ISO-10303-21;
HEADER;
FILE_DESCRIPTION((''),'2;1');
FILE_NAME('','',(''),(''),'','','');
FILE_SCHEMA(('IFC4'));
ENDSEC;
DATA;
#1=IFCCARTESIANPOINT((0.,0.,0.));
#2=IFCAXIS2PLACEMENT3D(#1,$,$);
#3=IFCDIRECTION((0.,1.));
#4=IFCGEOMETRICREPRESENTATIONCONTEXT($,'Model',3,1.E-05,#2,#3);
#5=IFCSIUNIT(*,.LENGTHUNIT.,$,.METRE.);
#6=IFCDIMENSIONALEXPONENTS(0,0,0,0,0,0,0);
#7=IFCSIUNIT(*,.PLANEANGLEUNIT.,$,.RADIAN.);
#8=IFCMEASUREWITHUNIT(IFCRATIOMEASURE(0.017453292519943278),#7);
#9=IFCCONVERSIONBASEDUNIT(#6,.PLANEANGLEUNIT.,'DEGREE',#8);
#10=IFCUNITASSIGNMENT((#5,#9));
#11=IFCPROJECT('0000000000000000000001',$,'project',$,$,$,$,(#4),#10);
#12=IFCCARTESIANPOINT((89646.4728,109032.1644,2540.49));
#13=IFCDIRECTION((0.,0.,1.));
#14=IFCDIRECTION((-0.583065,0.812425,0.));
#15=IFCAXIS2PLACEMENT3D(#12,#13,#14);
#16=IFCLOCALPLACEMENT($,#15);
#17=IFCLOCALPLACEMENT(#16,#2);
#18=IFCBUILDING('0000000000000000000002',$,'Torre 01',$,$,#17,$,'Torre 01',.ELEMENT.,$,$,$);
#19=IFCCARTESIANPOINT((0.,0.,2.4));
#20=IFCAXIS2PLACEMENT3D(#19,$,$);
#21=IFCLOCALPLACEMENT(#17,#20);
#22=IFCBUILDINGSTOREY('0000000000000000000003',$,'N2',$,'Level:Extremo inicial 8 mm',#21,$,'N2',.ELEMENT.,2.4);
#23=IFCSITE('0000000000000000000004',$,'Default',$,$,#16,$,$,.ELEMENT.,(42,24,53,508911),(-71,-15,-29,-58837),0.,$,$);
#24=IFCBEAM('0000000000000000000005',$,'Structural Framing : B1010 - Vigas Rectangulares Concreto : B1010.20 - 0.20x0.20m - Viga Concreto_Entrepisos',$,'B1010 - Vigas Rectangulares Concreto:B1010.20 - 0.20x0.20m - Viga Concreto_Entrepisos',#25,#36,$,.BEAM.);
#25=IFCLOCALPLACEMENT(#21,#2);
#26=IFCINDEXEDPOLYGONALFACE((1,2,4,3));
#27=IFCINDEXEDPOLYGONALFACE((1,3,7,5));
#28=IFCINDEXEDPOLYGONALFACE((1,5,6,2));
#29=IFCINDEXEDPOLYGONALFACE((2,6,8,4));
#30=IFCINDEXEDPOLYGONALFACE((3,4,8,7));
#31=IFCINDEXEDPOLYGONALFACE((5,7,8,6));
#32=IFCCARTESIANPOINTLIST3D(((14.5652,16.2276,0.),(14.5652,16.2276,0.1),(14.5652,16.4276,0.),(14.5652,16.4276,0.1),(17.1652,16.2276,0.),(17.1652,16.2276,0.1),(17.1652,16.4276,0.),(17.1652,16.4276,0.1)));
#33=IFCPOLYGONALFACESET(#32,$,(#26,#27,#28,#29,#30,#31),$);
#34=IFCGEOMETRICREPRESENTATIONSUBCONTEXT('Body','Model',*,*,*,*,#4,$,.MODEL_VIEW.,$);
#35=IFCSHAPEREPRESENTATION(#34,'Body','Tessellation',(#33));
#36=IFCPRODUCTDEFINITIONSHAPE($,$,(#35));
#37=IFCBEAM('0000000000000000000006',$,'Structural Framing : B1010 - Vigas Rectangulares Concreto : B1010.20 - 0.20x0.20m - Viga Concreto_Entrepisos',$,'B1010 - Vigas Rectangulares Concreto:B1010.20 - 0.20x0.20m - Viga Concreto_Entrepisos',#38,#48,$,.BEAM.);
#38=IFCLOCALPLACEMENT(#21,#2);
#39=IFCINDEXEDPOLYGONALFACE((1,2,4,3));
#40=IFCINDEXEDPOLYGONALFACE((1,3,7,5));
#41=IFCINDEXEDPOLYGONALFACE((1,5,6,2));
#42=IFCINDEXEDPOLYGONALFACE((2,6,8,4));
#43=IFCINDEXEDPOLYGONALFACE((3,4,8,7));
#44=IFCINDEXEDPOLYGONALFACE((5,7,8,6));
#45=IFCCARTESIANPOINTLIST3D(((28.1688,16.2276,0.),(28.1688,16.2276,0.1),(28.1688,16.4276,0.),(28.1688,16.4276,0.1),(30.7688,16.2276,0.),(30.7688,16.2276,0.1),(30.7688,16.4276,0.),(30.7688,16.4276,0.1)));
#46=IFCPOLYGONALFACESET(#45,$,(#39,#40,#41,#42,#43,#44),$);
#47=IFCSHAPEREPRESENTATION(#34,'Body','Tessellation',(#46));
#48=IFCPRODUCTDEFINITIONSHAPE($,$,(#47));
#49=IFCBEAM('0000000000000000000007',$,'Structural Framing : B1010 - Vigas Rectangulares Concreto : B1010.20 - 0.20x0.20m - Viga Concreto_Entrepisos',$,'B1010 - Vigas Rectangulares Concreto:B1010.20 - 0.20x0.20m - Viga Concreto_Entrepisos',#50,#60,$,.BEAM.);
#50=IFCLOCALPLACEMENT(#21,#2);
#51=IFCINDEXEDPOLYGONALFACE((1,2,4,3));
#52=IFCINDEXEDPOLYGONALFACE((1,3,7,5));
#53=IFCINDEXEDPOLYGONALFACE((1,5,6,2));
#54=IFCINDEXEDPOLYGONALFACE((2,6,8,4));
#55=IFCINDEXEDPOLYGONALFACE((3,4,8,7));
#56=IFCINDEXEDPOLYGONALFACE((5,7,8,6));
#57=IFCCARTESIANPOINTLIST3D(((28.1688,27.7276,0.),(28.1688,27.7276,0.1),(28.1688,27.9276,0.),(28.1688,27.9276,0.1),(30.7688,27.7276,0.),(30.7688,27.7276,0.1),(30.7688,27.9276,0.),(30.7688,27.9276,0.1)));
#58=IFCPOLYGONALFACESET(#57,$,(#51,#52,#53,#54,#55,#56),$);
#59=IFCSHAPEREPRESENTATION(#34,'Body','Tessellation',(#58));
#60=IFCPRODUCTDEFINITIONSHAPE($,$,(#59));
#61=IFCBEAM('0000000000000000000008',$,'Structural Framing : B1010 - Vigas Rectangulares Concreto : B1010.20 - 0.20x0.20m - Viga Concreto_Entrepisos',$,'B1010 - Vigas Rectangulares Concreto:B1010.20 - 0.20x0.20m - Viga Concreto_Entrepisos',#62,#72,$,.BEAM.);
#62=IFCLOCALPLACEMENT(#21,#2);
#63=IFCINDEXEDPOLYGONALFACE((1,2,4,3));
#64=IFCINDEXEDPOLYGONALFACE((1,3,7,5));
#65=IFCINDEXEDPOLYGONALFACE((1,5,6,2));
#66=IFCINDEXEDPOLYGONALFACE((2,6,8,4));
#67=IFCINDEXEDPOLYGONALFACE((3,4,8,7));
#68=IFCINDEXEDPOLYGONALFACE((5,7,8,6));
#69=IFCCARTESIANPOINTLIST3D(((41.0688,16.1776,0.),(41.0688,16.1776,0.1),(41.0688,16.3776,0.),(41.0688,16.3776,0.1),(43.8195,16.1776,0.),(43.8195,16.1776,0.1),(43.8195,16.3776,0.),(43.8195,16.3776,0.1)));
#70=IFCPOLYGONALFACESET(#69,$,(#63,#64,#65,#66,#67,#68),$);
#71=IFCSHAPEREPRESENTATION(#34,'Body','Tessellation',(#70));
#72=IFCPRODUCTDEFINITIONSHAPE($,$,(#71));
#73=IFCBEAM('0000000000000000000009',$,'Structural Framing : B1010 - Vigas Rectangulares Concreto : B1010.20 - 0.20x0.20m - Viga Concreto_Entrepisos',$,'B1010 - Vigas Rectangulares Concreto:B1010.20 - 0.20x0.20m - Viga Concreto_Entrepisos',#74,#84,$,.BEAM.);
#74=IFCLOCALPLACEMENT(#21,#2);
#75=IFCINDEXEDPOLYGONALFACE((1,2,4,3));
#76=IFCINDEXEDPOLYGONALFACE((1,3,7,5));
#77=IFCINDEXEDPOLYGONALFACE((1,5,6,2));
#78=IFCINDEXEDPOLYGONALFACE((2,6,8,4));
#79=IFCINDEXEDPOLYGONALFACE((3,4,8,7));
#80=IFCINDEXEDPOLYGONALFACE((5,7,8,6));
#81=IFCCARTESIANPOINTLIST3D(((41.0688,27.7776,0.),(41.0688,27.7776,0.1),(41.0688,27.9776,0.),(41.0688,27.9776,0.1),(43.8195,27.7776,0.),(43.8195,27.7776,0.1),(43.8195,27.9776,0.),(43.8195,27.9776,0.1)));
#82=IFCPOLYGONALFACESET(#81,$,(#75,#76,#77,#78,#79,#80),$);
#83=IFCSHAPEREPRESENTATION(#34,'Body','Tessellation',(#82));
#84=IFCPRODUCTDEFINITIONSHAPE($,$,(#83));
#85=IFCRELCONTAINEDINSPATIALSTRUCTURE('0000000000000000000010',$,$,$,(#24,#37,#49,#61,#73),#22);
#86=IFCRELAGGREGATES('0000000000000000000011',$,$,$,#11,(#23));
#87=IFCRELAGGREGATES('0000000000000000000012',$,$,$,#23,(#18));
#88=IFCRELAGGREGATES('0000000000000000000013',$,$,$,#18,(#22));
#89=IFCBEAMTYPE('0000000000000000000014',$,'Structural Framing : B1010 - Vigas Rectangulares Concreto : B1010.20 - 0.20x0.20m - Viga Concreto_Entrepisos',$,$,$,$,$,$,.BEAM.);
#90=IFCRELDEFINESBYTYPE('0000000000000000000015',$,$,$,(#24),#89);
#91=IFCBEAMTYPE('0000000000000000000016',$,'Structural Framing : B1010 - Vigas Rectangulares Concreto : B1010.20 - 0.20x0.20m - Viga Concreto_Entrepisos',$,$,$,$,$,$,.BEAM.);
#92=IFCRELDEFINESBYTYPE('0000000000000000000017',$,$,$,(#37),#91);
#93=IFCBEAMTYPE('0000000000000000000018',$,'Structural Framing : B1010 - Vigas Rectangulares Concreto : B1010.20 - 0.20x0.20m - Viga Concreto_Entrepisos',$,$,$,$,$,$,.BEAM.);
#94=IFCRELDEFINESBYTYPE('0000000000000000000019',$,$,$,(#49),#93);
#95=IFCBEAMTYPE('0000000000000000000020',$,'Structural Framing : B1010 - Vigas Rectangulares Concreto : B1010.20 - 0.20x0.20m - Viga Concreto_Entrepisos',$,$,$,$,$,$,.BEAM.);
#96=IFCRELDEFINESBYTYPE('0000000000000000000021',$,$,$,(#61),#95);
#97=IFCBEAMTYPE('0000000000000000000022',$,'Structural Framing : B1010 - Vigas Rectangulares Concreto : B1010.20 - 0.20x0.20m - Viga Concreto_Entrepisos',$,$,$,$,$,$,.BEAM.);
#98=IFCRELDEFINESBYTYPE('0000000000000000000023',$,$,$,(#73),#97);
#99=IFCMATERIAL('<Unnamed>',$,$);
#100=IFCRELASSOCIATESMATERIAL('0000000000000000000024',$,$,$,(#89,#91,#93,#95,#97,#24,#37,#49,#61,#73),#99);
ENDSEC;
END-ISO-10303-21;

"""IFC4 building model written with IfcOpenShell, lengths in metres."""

from ifc_helpers import new_model, entity, si_unit, converted_unit, direction, frame, frame_2d, origin, origin_2d_with_axis, place, context, subcontext, project, spatial, polyline, segment, composite_curve, rectangle, outline, extrude, source, transform, mapped, material, material_profile, profile_set, profile_usage, type_object, type_shapes, element, save


model = new_model("IFC4")

# Units and contexts
model_context = context("Model", 3, precision=1e-05, world=origin(), true_north=direction((0.0, 1.0)))
body_context = subcontext(model_context, "Body", "Model", "MODEL_VIEW")
ifc_project = project(units=[si_unit("LENGTHUNIT", "METRE"), converted_unit("PLANEANGLEUNIT", "DEGREE", entity("IfcRatioMeasure", 0.017453292519943278), si_unit("PLANEANGLEUNIT", "RADIAN"), dimensions=[0, 0, 0, 0, 0, 0, 0])], contexts=[model_context])

# Site, building, storey
site_placement = place(None, frame((89646.4728, 109032.1644, 2540.49), z_axis=(0.0, 0.0, 1.0), x_axis=(-0.583065, 0.812425, 0.0)))
site = spatial("IfcSite", under=ifc_project, at=site_placement, Name="Default", CompositionType="ELEMENT", RefLatitude=(42, 24, 53, 508911), RefLongitude=(-71, -15, -29, -58837), RefElevation=0.0)
building_placement = place(site_placement, origin())
building = spatial("IfcBuilding", under=site, at=building_placement, Name="Torre 01", LongName="Torre 01", CompositionType="ELEMENT")
storey_placement = place(building_placement, frame((0.0, 0.0, 2.4)))
storey = spatial("IfcBuildingStorey", under=building, at=storey_placement, Name="N2", ObjectType="Level:Extremo inicial 8 mm", LongName="N2", CompositionType="ELEMENT", Elevation=2.4)

# Beams
ifc_material = material(Name="<Unnamed>")
ifc_material_profile_1 = material_profile(ifc_material, outline(composite_curve([segment(polyline([(-0.1, 0.0, 0.0), (-0.1, 0.1, 0.0)]), True, "CONTINUOUS"), segment(polyline([(-0.1, 0.1, 0.0), (0.1, 0.1, 0.0)]), True, "CONTINUOUS"), segment(polyline([(0.1, 0.1, 0.0), (0.1, 0.0, 0.0)]), True, "CONTINUOUS"), segment(polyline([(0.1, 0.0, 0.0), (-0.1, 0.0, 0.0)]), True, "CONTINUOUS")], self_intersect=False), kind="CURVE"), Name="B1010.20 - 0.20x0.20m - Viga Concreto_Entrepisos")
ifc_material_profile_2 = material_profile(ifc_material, outline(composite_curve([segment(polyline([(-1.3, -0.1, 0.1), (-1.3, 0.1, 0.1)]), True, "CONTINUOUS"), segment(polyline([(-1.3, 0.1, 0.1), (-1.3, 0.1, -0.1)]), True, "CONTINUOUS"), segment(polyline([(-1.3, 0.1, -0.1), (-1.3, -0.1, -0.1)]), True, "CONTINUOUS"), segment(polyline([(-1.3, -0.1, -0.1), (-1.3, -0.1, 0.1)]), True, "CONTINUOUS")], self_intersect=False), kind="CURVE"), Name="B1010.20 - 0.20x0.20m - Viga Concreto_Entrepisos")
ifc_profile_set_1 = profile_set([ifc_material_profile_1, ifc_material_profile_2], Name="B1010.20 - 0.20x0.20m - Viga Concreto_Entrepisos")
ifc_profile_usage_1 = profile_usage(ifc_profile_set_1, cardinal=8)
beam_type_1 = type_object("IfcBeamType", Name="Structural Framing : B1010 - Vigas Rectangulares Concreto : B1010.20 - 0.20x0.20m - Viga Concreto_Entrepisos", PredefinedType="BEAM", material=ifc_profile_set_1)
shared_shape_1 = source(origin(), body_context, "Body", "SweptSolid", [
    extrude(rectangle(XDim=0.1, YDim=0.2, at=frame_2d((0.0, 0.0), x_axis=(1.0, 0.0))), frame((17.1652, 16.3276, 2.45), z_axis=(-1.0, 0.0, 0.0), x_axis=(0.0, 0.0, -1.0)), (0.0, 0.0, 1.0), 2.6),
])
type_shapes(beam_type_1, [shared_shape_1])
beam_1_placement = place(storey_placement, frame((0.0, 0.0, -2.4)))
element("IfcBeam", 1, at=beam_1_placement, inside=storey, type_object=beam_type_1, material=ifc_profile_usage_1, Name="Structural Framing : B1010 - Vigas Rectangulares Concreto : B1010.20 - 0.20x0.20m - Viga Concreto_Entrepisos", ObjectType="B1010 - Vigas Rectangulares Concreto:B1010.20 - 0.20x0.20m - Viga Concreto_Entrepisos", PredefinedType="BEAM", context=body_context, shape_type="MappedRepresentation", body=[
    mapped(shared_shape_1, transform((0.0, 0.0, 0.0), scale=1.0)),
])
ifc_profile_usage_2 = profile_usage(ifc_profile_set_1, cardinal=8)
beam_type_2 = type_object("IfcBeamType", Name="Structural Framing : B1010 - Vigas Rectangulares Concreto : B1010.20 - 0.20x0.20m - Viga Concreto_Entrepisos", PredefinedType="BEAM", material=ifc_profile_set_1)
shared_shape_2 = source(origin(), body_context, "Body", "SweptSolid", [
    extrude(rectangle(XDim=0.1, YDim=0.2, at=frame_2d((0.0, 0.0), x_axis=(1.0, 0.0))), frame((28.1688, 16.3276, 2.45), z_axis=(1.0, 0.0, 0.0), x_axis=(0.0, 0.0, -1.0)), (0.0, 0.0, 1.0), 2.6),
])
type_shapes(beam_type_2, [shared_shape_2])
beam_2_placement = place(storey_placement, frame((0.0, 0.0, -2.4)))
element("IfcBeam", 2, at=beam_2_placement, inside=storey, type_object=beam_type_2, material=ifc_profile_usage_2, Name="Structural Framing : B1010 - Vigas Rectangulares Concreto : B1010.20 - 0.20x0.20m - Viga Concreto_Entrepisos", ObjectType="B1010 - Vigas Rectangulares Concreto:B1010.20 - 0.20x0.20m - Viga Concreto_Entrepisos", PredefinedType="BEAM", context=body_context, shape_type="MappedRepresentation", body=[
    mapped(shared_shape_2, transform((0.0, 0.0, 0.0), scale=1.0)),
])
ifc_profile_usage_3 = profile_usage(ifc_profile_set_1, cardinal=8)
beam_type_3 = type_object("IfcBeamType", Name="Structural Framing : B1010 - Vigas Rectangulares Concreto : B1010.20 - 0.20x0.20m - Viga Concreto_Entrepisos", PredefinedType="BEAM", material=ifc_profile_set_1)
shared_shape_3 = source(origin(), body_context, "Body", "SweptSolid", [
    extrude(rectangle(XDim=0.1, YDim=0.2, at=origin_2d_with_axis()), frame((28.1688, 27.8276, 2.45), z_axis=(1.0, 0.0, 0.0), x_axis=(0.0, 0.0, -1.0)), (0.0, 0.0, 1.0), 2.6),
])
type_shapes(beam_type_3, [shared_shape_3])
beam_3_placement = place(storey_placement, frame((0.0, 0.0, -2.4)))
element("IfcBeam", 3, at=beam_3_placement, inside=storey, type_object=beam_type_3, material=ifc_profile_usage_3, Name="Structural Framing : B1010 - Vigas Rectangulares Concreto : B1010.20 - 0.20x0.20m - Viga Concreto_Entrepisos", ObjectType="B1010 - Vigas Rectangulares Concreto:B1010.20 - 0.20x0.20m - Viga Concreto_Entrepisos", PredefinedType="BEAM", context=body_context, shape_type="MappedRepresentation", body=[
    mapped(shared_shape_3, transform((0.0, 0.0, 0.0), scale=1.0)),
])
ifc_profile_usage_4 = profile_usage(ifc_profile_set_1, cardinal=8)
beam_type_4 = type_object("IfcBeamType", Name="Structural Framing : B1010 - Vigas Rectangulares Concreto : B1010.20 - 0.20x0.20m - Viga Concreto_Entrepisos", PredefinedType="BEAM", material=ifc_profile_set_1)
shared_shape_4 = source(origin(), body_context, "Body", "SweptSolid", [
    extrude(rectangle(XDim=0.1, YDim=0.2, at=frame_2d((0.0, 0.0), x_axis=(1.0, 0.0))), frame((43.8195, 16.2776, 2.45), z_axis=(-1.0, 0.0, 0.0), x_axis=(0.0, 0.0, -1.0)), (0.0, 0.0, 1.0), 2.7507),
])
type_shapes(beam_type_4, [shared_shape_4])
beam_4_placement = place(storey_placement, frame((0.0, 0.0, -2.4)))
element("IfcBeam", 4, at=beam_4_placement, inside=storey, type_object=beam_type_4, material=ifc_profile_usage_4, Name="Structural Framing : B1010 - Vigas Rectangulares Concreto : B1010.20 - 0.20x0.20m - Viga Concreto_Entrepisos", ObjectType="B1010 - Vigas Rectangulares Concreto:B1010.20 - 0.20x0.20m - Viga Concreto_Entrepisos", PredefinedType="BEAM", context=body_context, shape_type="MappedRepresentation", body=[
    mapped(shared_shape_4, transform((0.0, 0.0, 0.0), scale=1.0)),
])
ifc_profile_usage_5 = profile_usage(ifc_profile_set_1, cardinal=8)
beam_type_5 = type_object("IfcBeamType", Name="Structural Framing : B1010 - Vigas Rectangulares Concreto : B1010.20 - 0.20x0.20m - Viga Concreto_Entrepisos", PredefinedType="BEAM", material=ifc_profile_set_1)
shared_shape_5 = source(origin(), body_context, "Body", "SweptSolid", [
    extrude(rectangle(XDim=0.1, YDim=0.2, at=origin_2d_with_axis()), frame((43.8195, 27.8776, 2.45), z_axis=(-1.0, 0.0, 0.0), x_axis=(0.0, 0.0, -1.0)), (0.0, 0.0, 1.0), 2.7507),
])
type_shapes(beam_type_5, [shared_shape_5])
beam_5_placement = place(storey_placement, frame((0.0, 0.0, -2.4)))
element("IfcBeam", 5, at=beam_5_placement, inside=storey, type_object=beam_type_5, material=ifc_profile_usage_5, Name="Structural Framing : B1010 - Vigas Rectangulares Concreto : B1010.20 - 0.20x0.20m - Viga Concreto_Entrepisos", ObjectType="B1010 - Vigas Rectangulares Concreto:B1010.20 - 0.20x0.20m - Viga Concreto_Entrepisos", PredefinedType="BEAM", context=body_context, shape_type="MappedRepresentation", body=[
    mapped(shared_shape_5, transform((0.0, 0.0, 0.0), scale=1.0)),
])

save(model, "model.ifc")
